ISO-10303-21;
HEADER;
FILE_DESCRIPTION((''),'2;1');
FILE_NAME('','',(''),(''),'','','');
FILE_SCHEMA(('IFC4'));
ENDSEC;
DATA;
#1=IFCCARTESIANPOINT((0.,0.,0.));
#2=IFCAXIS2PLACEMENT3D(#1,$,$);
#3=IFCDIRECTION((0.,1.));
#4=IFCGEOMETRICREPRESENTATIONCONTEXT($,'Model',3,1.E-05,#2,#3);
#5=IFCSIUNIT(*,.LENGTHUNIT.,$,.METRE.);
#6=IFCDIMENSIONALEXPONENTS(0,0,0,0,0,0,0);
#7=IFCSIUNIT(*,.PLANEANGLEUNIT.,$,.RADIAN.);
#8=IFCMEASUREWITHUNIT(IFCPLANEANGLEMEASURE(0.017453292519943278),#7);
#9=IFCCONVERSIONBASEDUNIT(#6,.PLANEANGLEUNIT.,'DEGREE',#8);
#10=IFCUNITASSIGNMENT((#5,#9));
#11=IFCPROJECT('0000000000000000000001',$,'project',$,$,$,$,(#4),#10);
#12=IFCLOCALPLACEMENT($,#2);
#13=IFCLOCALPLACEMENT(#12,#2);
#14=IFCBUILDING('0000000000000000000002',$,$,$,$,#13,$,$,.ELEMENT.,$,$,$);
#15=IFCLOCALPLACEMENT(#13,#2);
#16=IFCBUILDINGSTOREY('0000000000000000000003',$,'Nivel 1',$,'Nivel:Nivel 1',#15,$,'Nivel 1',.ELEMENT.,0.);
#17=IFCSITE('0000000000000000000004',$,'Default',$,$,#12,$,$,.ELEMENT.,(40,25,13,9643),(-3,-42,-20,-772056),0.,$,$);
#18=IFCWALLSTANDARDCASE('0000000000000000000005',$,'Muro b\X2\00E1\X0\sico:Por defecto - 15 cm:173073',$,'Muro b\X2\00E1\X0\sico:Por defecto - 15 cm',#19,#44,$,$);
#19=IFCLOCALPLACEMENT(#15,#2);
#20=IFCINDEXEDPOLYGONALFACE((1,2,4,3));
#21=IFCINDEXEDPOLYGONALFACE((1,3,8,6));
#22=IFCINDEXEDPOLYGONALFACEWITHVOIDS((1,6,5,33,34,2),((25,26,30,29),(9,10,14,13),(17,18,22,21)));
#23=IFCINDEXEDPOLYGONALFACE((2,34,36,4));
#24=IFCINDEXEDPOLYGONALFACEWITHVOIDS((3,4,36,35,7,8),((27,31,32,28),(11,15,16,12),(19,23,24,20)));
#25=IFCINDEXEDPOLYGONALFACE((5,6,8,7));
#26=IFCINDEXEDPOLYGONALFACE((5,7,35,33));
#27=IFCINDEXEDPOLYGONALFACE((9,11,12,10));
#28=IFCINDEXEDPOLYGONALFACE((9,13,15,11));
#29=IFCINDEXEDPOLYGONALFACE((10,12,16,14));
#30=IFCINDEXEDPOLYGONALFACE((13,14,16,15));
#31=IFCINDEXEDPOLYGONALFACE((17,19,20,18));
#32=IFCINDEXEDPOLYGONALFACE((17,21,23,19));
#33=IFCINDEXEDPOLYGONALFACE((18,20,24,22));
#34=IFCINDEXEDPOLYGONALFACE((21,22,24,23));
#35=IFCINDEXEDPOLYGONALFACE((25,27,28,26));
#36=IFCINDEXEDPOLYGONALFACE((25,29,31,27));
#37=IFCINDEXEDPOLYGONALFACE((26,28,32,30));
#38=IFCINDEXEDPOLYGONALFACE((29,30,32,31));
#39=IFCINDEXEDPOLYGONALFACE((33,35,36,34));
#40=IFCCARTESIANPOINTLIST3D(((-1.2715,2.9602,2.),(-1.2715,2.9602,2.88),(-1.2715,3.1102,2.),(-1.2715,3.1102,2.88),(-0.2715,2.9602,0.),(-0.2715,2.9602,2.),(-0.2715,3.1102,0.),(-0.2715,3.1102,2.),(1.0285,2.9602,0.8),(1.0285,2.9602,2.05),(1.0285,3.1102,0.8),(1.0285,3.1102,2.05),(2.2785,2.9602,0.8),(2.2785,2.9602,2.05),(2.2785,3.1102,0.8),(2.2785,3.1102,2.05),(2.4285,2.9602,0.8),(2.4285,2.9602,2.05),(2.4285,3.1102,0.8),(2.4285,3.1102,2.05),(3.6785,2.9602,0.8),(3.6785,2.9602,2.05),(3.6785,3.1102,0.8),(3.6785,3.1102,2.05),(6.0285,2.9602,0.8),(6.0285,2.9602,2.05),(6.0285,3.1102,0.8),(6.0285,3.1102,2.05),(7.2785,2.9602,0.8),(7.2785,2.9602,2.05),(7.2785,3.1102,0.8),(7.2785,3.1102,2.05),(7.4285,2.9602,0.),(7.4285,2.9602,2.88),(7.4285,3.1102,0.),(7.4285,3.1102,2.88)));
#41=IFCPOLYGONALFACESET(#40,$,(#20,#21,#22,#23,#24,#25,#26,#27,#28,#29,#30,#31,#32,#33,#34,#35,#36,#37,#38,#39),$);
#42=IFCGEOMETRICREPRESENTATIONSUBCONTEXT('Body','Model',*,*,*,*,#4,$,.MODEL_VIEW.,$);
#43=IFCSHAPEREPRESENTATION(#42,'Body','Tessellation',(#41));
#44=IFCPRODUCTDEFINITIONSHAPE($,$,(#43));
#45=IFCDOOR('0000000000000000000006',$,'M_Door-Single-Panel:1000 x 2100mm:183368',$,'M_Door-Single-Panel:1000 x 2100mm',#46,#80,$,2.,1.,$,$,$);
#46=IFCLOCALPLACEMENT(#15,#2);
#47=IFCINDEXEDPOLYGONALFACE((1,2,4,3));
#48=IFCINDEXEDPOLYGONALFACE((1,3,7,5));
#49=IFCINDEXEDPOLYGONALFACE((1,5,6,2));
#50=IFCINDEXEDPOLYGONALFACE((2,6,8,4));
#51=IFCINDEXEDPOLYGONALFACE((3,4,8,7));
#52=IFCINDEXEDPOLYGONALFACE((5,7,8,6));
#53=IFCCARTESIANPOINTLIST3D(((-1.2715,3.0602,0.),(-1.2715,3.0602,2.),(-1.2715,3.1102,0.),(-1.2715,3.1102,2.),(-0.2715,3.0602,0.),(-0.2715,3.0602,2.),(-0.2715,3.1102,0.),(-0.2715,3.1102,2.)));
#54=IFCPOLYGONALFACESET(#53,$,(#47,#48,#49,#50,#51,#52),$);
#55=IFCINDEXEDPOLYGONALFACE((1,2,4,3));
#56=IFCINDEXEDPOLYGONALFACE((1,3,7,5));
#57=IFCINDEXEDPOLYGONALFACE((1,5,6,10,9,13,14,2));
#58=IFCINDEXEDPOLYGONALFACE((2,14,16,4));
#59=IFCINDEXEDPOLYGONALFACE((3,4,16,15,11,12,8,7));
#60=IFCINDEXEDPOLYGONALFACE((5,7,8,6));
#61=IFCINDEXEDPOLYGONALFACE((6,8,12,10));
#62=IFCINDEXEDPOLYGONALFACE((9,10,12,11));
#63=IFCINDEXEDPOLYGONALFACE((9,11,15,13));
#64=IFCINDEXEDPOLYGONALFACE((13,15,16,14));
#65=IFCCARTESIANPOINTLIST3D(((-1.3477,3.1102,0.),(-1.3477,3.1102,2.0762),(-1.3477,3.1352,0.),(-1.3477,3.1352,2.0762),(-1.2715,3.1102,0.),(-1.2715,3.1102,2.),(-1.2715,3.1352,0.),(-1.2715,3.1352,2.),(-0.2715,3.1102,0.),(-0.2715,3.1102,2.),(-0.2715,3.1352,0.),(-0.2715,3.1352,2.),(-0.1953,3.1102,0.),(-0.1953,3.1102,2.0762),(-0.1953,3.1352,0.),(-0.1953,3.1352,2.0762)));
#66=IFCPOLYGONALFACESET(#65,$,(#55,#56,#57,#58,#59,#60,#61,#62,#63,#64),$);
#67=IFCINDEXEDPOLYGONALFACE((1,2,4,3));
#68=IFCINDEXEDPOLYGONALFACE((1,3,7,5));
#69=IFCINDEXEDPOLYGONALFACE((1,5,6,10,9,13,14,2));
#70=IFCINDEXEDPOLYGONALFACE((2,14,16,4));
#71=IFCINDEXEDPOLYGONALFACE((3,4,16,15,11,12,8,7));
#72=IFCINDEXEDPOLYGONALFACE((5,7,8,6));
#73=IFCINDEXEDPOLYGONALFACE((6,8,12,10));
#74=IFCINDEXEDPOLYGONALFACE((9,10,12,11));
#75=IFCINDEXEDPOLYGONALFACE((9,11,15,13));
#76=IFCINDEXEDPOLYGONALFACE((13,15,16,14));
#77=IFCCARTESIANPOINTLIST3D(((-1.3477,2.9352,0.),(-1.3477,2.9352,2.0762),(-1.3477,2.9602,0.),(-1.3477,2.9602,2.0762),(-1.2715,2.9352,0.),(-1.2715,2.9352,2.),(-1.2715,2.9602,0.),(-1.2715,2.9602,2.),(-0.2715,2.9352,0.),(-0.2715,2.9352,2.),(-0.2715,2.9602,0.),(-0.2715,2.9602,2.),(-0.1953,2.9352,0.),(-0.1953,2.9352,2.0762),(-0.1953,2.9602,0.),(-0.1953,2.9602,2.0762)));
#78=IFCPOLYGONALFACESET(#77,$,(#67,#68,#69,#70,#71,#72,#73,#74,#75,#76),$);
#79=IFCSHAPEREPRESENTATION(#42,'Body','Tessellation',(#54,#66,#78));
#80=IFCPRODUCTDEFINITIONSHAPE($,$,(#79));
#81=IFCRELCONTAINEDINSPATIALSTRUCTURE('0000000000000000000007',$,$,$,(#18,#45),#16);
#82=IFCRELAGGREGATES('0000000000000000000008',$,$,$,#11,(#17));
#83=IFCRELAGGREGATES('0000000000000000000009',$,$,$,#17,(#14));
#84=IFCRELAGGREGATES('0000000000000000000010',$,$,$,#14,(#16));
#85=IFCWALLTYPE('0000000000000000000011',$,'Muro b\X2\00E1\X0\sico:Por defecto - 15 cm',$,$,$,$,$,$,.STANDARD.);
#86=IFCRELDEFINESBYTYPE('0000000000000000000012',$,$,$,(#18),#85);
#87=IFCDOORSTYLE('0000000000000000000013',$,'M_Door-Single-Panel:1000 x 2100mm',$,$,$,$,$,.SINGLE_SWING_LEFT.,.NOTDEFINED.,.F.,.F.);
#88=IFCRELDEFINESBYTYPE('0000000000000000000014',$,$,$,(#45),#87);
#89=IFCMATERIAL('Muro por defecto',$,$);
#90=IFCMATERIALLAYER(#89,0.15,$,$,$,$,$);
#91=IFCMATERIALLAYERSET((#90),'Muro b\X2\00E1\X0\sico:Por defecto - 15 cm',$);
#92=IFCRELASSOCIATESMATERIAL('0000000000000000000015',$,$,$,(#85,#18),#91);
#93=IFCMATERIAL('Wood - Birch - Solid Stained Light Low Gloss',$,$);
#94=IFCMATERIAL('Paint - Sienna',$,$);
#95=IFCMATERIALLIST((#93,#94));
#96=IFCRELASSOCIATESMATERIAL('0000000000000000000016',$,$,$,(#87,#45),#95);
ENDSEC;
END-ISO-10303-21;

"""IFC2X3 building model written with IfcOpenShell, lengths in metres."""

from ifc_helpers import new_model, entity, si_unit, converted_unit, direction, frame, frame_2d, origin, origin_2d_with_axis, place, context, subcontext, project, spatial, polyline, rectangle, outline, extrude, clip, bounded_halfspace, source, transform, mapped, material, material_list, layer, layer_set, layer_usage, type_object, type_shapes, element, fill, save


model = new_model("IFC2X3")

# Units and contexts
model_context = context("Model", 3, precision=1e-05, world=origin(), true_north=direction((0.0, 1.0)))
body_context = subcontext(model_context, "Body", "Model", "MODEL_VIEW")
ifc_project = project(units=[si_unit("LENGTHUNIT", "METRE"), converted_unit("PLANEANGLEUNIT", "DEGREE", entity("IfcPlaneAngleMeasure", 0.017453292519943278), si_unit("PLANEANGLEUNIT", "RADIAN"), dimensions=[0, 0, 0, 0, 0, 0, 0])], contexts=[model_context])

# Site, building, storey
site_placement = place(None, origin())
site = spatial("IfcSite", under=ifc_project, at=site_placement, Name="Default", CompositionType="ELEMENT", RefLatitude=(40, 25, 13, 9643), RefLongitude=(-3, -42, -20, -772056), RefElevation=0.0)
building_placement = place(site_placement, origin())
building = spatial("IfcBuilding", under=site, at=building_placement, CompositionType="ELEMENT")
storey_placement = place(building_placement, origin())
storey = spatial("IfcBuildingStorey", under=building, at=storey_placement, Name="Nivel 1", ObjectType="Nivel:Nivel 1", LongName="Nivel 1", CompositionType="ELEMENT", Elevation=0.0)

# Shared definitions
ifc_material_1 = material(Name="Muro por defecto")
ifc_layer = layer(ifc_material_1, 0.15)
ifc_layer_set = layer_set([ifc_layer], Name="Muro básico:Por defecto - 15 cm")
wall_type = type_object("IfcWallType", Name="Muro básico:Por defecto - 15 cm", PredefinedType="STANDARD", material=ifc_layer_set)

# Wall, openings, door
ifc_layer_usage_1 = layer_usage(ifc_layer_set, "AXIS2", "POSITIVE", -0.075)
wall_1_placement = place(storey_placement, frame((7.4285, 3.0352, 0.0), z_axis=(0.0, 0.0, 1.0), x_axis=(-1.0, 0.0, 0.0)))
wall_1 = element("IfcWallStandardCase", 1, at=wall_1_placement, inside=storey, type_object=wall_type, material=ifc_layer_usage_1, Name="Muro básico:Por defecto - 15 cm:173073", ObjectType="Muro básico:Por defecto - 15 cm", context=body_context, shape_type="Clipping", body=[
    clip(extrude(rectangle(XDim=8.7, YDim=0.15, at=frame_2d((4.35, 0.0), x_axis=(-1.0, 0.0))), origin(), (0.0, 0.0, 1.0), 2.88), bounded_halfspace(frame((0.0, -0.075, 2.88), z_axis=(0.0, 0.0, -1.0), x_axis=(-1.0, 0.0, 0.0)), True, frame((0.0, -0.075, 2.88)), polyline([(0.0, 0.0), (8.7, 0.0), (8.7, 0.15), (5.15, 0.15), (5.0, 0.15), (0.15, 0.15), (0.0, 0.15), (0.0, 0.0)]))),
])
opening_1_placement = place(wall_1_placement, frame((8.7, 0.075, 0.0)))
opening_1 = element("IfcOpeningElement", 2, at=opening_1_placement, cuts=wall_1, ObjectType="Opening", context=body_context, shape_type="SweptSolid", body=[
    extrude(rectangle(XDim=1.0, YDim=2.0, at=frame_2d((1.0, 0.5), x_axis=(0.0, -1.0))), frame((0.0, 0.0, 0.0), z_axis=(0.0, -1.0, 0.0), x_axis=(0.0, 0.0, 1.0)), (0.0, 0.0, 1.0), 0.15),
])
opening_2_placement = place(wall_1_placement, frame((6.4, 0.075, 0.8)))
element("IfcOpeningElement", 3, at=opening_2_placement, cuts=wall_1, ObjectType="Opening", context=body_context, shape_type="SweptSolid", body=[
    extrude(rectangle(XDim=1.25, YDim=1.25, at=frame_2d((0.625, 0.625), x_axis=(1.0, 0.0))), frame((0.0, 0.0, 0.0), z_axis=(0.0, -1.0, 0.0), x_axis=(0.0, 0.0, 1.0)), (0.0, 0.0, 1.0), 0.15),
])
opening_3_placement = place(wall_1_placement, frame((5.0, 0.075, 0.8)))
element("IfcOpeningElement", 4, at=opening_3_placement, cuts=wall_1, ObjectType="Opening", context=body_context, shape_type="SweptSolid", body=[
    extrude(rectangle(XDim=1.25, YDim=1.25, at=frame_2d((0.625, 0.625), x_axis=(1.0, 0.0))), frame((0.0, 0.0, 0.0), z_axis=(0.0, -1.0, 0.0), x_axis=(0.0, 0.0, 1.0)), (0.0, 0.0, 1.0), 0.15),
])
opening_4_placement = place(wall_1_placement, frame((1.4, 0.075, 0.8)))
element("IfcOpeningElement", 5, at=opening_4_placement, cuts=wall_1, ObjectType="Opening", context=body_context, shape_type="SweptSolid", body=[
    extrude(rectangle(XDim=1.25, YDim=1.25, at=frame_2d((0.625, 0.625), x_axis=(1.0, 0.0))), frame((0.0, 0.0, 0.0), z_axis=(0.0, -1.0, 0.0), x_axis=(0.0, 0.0, 1.0)), (0.0, 0.0, 1.0), 0.15),
])
ifc_material_2 = material(Name="Wood - Birch - Solid Stained Light Low Gloss")
ifc_material_3 = material(Name="Paint - Sienna")
ifc_material_list_1 = material_list([ifc_material_2, ifc_material_3])
door_style_1 = type_object("IfcDoorStyle", Name="M_Door-Single-Panel:1000 x 2100mm", ConstructionType="NOTDEFINED", OperationType="SINGLE_SWING_LEFT", ParameterTakesPrecedence=False, Sizeable=False, material=ifc_material_list_1)
shared_shape_1 = source(origin(), body_context, "Body", "SweptSolid", [
    extrude(rectangle(XDim=1.0, YDim=0.05, at=origin_2d_with_axis()), frame((0.5, 0.125, 0.0)), (0.0, 0.0, 1.0), 2.0),
    extrude(outline(polyline([(-0.5762, -1.0571), (0.5762, -1.0571), (0.5762, 1.0191), (0.5, 1.0191), (0.5, -0.981), (-0.5, -0.981), (-0.5, 1.0191), (-0.5762, 1.0191), (-0.5762, -1.0571)])), frame((0.5, 0.175, 1.0191), z_axis=(0.0, -1.0, 0.0), x_axis=(-1.0, 0.0, 0.0)), (0.0, 0.0, 1.0), 0.025),
    extrude(outline(polyline([(-1.0571, -0.5762), (1.019, -0.5762), (1.019, -0.5), (-0.9809, -0.5), (-0.9809, 0.5), (1.019, 0.5), (1.019, 0.5762), (-1.0571, 0.5762), (-1.0571, -0.5762)])), frame((0.5, 0.0, 1.019), z_axis=(0.0, -1.0, 0.0), x_axis=(0.0, 0.0, -1.0)), (0.0, 0.0, 1.0), 0.025),
])
type_shapes(door_style_1, [shared_shape_1])
door_1_placement = place(opening_1_placement, frame((0.0, 0.0, 0.0), z_axis=(0.0, 0.0, 1.0), x_axis=(-1.0, 0.0, 0.0)))
door_1 = element("IfcDoor", 6, at=door_1_placement, inside=storey, type_object=door_style_1, material=ifc_material_list_1, Name="M_Door-Single-Panel:1000 x 2100mm:183368", ObjectType="M_Door-Single-Panel:1000 x 2100mm", OverallHeight=2.0, OverallWidth=1.0, context=body_context, shape_type="MappedRepresentation", body=[
    mapped(shared_shape_1, transform((0.0, 0.0, 0.0), scale=1.0)),
])
fill(opening_1, door_1)

save(model, "model.ifc")
